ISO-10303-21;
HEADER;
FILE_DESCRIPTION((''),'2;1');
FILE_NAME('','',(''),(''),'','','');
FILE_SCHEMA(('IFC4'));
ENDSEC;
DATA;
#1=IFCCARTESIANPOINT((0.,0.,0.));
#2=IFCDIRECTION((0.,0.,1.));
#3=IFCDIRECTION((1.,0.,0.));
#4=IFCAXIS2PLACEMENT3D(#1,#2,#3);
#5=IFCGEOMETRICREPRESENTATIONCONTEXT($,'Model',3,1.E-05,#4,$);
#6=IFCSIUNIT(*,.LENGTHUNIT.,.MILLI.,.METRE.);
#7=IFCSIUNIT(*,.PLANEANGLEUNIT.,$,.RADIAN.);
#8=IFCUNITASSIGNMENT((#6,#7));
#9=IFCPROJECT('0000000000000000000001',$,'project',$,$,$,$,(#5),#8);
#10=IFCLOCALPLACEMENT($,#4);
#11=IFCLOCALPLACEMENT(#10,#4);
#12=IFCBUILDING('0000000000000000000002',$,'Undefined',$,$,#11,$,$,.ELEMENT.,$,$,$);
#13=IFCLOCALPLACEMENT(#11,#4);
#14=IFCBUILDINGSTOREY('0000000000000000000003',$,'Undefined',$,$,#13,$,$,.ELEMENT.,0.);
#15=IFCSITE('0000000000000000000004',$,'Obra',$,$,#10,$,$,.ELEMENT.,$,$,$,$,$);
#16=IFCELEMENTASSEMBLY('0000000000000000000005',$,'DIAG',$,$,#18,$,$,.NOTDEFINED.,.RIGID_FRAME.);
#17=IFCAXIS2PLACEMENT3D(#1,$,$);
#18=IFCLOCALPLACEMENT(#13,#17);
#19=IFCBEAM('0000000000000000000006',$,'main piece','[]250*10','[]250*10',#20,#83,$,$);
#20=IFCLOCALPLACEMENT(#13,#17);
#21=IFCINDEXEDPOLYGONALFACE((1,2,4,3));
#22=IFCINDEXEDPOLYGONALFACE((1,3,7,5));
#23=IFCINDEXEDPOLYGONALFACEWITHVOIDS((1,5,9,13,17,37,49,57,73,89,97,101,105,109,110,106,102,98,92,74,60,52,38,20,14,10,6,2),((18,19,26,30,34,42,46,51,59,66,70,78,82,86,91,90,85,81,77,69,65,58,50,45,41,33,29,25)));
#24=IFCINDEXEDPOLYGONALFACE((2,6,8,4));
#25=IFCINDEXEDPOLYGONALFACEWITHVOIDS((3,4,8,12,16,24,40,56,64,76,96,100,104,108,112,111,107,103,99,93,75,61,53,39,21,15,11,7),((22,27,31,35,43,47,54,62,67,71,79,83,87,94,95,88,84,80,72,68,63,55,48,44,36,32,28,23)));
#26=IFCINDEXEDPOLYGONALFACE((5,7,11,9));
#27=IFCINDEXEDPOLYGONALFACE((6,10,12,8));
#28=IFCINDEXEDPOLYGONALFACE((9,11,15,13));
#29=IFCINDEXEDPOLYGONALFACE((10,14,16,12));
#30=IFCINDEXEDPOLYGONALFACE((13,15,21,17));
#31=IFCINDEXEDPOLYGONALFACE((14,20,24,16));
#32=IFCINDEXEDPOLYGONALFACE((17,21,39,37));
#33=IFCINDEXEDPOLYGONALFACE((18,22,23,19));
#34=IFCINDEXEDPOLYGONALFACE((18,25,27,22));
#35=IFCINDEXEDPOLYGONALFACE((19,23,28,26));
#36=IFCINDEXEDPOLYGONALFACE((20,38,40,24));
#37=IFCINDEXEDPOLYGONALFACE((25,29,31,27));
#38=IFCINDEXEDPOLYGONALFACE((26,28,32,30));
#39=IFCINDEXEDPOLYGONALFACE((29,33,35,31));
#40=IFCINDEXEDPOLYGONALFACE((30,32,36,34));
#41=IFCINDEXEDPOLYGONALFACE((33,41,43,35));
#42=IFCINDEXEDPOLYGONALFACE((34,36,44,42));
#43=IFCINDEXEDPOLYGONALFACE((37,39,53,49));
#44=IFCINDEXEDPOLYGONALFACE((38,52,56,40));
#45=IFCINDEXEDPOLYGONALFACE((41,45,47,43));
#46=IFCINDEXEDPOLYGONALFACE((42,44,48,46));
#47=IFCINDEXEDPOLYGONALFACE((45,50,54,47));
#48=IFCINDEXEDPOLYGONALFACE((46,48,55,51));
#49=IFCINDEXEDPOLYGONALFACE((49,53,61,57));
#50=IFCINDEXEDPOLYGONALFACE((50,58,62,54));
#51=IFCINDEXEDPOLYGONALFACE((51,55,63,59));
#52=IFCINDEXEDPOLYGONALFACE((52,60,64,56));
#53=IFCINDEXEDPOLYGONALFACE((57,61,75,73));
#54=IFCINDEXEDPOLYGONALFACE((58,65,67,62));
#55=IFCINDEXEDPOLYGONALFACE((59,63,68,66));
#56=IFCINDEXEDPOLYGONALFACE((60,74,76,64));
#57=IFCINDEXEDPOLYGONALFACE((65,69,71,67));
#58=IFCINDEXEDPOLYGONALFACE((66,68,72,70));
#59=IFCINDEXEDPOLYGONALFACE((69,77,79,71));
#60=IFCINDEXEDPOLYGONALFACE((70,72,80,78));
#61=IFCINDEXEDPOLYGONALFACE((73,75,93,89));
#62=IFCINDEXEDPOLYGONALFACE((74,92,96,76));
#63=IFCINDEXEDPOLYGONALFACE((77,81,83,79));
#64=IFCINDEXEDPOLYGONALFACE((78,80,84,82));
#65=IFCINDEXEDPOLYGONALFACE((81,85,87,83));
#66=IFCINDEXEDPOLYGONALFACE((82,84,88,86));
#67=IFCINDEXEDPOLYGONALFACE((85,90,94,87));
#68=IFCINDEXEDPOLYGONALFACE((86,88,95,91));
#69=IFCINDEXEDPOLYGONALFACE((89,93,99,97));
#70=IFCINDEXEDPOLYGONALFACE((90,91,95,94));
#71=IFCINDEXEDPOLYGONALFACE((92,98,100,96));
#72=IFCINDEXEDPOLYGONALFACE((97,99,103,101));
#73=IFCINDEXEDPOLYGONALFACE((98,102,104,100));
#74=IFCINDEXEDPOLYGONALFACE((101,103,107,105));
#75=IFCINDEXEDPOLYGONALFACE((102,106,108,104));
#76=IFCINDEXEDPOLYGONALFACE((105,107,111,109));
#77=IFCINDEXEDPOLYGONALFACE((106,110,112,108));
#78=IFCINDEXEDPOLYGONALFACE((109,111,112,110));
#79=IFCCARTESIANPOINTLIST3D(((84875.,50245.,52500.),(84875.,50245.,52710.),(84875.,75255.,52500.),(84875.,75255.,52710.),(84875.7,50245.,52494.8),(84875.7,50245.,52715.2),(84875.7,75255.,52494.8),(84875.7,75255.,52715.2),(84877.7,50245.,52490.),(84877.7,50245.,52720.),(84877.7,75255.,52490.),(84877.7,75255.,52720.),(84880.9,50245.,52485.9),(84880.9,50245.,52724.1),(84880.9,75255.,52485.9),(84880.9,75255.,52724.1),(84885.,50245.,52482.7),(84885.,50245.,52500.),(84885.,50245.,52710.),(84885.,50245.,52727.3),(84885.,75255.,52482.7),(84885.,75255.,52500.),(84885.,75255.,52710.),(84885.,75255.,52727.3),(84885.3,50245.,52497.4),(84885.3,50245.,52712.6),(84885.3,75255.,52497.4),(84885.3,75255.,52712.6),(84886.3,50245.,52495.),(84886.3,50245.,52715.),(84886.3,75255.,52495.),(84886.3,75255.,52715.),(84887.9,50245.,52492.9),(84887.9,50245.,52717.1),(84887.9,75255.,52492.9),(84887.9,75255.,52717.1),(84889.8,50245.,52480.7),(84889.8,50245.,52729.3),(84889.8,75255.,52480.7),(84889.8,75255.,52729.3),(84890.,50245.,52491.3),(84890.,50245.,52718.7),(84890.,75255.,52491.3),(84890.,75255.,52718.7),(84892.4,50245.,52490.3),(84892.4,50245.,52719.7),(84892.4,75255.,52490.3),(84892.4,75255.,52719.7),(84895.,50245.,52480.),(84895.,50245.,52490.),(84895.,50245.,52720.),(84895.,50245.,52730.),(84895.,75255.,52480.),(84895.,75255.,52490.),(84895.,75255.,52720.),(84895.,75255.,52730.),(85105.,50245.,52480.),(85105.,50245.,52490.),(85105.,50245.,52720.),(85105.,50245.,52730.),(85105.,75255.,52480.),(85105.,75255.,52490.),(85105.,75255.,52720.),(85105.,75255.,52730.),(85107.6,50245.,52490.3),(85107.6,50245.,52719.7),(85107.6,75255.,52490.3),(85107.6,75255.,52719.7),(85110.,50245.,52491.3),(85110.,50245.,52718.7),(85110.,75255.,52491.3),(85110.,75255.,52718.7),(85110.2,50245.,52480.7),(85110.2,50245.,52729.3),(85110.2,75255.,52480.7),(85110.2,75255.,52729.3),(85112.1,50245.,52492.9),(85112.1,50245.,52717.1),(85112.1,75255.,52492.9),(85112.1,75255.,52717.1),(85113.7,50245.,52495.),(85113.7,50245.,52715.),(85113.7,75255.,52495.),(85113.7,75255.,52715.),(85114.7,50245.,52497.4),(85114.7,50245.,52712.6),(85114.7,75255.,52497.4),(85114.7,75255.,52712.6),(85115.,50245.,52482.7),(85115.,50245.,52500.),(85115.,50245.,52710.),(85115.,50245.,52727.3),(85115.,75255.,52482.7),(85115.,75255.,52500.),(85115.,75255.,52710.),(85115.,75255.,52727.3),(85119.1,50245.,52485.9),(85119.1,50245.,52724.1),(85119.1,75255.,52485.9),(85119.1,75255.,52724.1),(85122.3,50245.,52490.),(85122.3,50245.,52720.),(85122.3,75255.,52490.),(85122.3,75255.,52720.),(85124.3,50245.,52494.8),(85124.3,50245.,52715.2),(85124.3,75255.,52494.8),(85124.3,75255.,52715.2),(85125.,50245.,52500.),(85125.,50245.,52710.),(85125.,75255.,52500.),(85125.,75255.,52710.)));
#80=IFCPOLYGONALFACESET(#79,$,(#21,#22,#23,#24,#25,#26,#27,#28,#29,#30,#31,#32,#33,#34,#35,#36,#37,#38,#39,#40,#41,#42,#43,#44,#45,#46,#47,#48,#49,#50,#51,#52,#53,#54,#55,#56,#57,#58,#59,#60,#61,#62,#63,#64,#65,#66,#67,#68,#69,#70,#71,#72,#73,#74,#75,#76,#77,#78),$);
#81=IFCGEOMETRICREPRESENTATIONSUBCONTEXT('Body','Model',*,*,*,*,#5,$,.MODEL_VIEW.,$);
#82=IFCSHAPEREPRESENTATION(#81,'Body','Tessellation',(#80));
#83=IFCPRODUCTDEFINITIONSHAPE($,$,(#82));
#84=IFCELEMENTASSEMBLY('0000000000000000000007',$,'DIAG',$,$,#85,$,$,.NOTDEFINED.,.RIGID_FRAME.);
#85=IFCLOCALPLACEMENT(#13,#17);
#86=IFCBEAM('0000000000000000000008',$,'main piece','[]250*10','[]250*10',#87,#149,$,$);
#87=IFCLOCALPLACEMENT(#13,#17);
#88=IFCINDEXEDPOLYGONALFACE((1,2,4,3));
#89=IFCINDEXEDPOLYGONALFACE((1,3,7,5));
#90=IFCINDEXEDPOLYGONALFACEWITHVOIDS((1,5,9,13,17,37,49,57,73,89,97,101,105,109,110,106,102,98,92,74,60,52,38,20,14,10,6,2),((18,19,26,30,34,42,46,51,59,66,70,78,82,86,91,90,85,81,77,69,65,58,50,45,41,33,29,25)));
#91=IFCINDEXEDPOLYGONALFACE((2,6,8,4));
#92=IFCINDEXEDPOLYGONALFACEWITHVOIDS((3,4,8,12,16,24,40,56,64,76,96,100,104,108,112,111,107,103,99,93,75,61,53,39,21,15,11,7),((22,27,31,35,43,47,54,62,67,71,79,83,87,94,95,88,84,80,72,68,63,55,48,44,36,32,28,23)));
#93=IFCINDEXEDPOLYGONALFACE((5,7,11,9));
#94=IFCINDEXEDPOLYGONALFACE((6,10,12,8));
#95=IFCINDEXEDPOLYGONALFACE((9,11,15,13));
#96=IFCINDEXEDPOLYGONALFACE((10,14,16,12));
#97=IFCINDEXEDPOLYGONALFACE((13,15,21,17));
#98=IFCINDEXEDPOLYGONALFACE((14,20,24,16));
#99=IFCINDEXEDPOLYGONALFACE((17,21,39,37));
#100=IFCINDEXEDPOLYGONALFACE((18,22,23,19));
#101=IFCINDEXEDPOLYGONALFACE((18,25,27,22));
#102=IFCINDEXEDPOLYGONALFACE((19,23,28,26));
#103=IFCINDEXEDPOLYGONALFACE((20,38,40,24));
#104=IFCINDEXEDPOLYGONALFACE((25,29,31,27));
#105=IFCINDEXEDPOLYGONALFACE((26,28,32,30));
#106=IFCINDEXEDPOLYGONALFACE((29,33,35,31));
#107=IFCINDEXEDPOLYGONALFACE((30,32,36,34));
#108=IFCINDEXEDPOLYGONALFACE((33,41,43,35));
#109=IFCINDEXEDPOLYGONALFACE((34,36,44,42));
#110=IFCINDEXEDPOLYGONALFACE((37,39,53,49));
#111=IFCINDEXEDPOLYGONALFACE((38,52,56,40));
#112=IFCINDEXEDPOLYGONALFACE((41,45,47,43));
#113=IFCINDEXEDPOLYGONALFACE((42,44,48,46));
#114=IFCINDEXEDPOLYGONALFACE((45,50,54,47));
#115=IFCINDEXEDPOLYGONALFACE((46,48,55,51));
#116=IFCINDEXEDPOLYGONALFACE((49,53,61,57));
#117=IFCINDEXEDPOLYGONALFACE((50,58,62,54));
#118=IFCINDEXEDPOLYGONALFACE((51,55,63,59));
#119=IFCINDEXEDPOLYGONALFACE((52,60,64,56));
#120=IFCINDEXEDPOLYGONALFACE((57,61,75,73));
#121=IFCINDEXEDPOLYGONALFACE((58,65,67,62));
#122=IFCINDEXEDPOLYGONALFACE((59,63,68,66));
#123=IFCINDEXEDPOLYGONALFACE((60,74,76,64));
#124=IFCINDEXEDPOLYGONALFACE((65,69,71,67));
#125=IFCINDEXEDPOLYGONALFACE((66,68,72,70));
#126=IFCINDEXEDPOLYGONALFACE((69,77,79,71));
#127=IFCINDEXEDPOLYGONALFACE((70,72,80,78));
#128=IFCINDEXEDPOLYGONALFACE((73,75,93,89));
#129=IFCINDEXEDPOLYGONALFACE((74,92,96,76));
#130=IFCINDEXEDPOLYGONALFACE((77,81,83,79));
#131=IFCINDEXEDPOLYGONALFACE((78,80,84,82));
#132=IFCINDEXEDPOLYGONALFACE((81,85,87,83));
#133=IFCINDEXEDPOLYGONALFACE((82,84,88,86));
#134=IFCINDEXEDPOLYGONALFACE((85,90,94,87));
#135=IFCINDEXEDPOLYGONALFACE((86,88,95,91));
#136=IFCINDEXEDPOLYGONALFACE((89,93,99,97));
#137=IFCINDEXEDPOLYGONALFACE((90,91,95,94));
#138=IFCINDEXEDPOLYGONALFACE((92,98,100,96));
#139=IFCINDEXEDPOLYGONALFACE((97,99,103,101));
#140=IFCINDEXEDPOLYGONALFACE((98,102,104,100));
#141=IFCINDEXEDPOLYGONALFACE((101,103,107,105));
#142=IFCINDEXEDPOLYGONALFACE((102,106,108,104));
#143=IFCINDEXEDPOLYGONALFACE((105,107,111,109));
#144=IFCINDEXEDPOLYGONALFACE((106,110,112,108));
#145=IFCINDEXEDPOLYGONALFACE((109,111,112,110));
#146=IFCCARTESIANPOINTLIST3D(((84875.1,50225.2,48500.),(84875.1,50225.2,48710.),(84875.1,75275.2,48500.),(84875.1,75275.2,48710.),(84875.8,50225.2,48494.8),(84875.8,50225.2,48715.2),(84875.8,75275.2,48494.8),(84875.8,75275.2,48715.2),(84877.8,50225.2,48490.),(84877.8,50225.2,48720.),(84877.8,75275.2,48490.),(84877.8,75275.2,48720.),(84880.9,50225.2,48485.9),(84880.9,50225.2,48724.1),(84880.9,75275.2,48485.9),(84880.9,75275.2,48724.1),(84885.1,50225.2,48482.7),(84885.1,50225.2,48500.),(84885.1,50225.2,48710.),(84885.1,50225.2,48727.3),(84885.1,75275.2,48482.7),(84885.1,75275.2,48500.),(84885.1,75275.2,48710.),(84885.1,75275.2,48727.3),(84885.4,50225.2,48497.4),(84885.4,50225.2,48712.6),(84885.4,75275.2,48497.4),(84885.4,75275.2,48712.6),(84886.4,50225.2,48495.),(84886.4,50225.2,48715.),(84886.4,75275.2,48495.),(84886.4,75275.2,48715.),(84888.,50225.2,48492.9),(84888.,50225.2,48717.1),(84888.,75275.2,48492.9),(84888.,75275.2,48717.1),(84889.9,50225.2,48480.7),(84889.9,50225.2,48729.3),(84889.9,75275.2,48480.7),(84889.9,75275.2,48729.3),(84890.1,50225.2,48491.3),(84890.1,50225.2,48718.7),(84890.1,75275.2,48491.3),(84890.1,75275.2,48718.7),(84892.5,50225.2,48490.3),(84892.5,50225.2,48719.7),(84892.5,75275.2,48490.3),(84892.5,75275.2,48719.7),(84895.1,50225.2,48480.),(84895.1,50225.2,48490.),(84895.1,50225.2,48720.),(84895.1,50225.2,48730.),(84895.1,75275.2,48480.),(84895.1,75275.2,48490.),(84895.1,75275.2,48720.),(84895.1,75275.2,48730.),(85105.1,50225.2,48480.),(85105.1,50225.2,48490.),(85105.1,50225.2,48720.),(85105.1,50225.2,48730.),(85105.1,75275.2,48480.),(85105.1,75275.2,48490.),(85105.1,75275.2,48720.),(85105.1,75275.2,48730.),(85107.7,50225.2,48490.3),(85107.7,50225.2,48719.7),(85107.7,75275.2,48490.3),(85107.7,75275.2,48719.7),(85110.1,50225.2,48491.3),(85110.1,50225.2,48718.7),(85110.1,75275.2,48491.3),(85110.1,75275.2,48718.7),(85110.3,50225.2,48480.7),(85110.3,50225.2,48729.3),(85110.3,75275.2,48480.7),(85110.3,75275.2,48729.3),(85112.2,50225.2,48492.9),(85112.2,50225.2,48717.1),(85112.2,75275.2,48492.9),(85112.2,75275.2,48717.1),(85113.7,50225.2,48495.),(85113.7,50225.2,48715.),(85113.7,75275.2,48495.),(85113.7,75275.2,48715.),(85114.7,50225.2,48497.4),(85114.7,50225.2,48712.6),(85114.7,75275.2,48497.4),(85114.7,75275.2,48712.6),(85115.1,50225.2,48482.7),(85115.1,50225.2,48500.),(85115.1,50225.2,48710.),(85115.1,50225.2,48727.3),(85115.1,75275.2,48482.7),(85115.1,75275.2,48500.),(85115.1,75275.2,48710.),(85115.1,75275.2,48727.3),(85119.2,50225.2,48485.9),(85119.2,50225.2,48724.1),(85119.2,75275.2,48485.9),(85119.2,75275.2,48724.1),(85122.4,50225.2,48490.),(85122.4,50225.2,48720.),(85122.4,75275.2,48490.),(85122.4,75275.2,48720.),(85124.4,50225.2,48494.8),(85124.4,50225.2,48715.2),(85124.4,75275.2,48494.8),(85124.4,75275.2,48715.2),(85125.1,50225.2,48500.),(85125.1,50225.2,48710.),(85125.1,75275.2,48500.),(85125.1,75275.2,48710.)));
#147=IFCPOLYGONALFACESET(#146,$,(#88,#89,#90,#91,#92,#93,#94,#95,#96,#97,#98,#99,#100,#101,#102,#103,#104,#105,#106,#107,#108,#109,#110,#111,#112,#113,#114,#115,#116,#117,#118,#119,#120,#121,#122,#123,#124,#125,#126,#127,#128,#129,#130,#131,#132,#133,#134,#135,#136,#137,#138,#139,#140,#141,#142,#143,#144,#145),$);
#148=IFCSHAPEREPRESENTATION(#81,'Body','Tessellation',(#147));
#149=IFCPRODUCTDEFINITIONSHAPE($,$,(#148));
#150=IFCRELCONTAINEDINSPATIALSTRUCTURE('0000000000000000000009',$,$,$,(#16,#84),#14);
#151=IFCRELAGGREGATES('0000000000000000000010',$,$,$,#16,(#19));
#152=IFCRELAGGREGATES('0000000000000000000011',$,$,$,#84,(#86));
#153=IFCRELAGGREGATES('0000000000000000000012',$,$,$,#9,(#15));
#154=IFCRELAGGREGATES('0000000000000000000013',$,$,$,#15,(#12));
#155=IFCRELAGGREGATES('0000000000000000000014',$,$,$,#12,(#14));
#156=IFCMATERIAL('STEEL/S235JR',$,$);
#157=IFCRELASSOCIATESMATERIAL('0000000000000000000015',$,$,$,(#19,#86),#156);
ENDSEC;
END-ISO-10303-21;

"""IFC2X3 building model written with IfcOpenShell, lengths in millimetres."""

from ifc_helpers import new_model, si_unit, frame, origin_with_axes, origin_2d_with_axis, place, context, subcontext, project, spatial, hollow_rectangle, extrude, material, element, aggregate, save


model = new_model("IFC2X3")

# Units and contexts
model_context = context("Model", 3, precision=1e-05, world=origin_with_axes())
body_context = subcontext(model_context, "Body", "Model", "MODEL_VIEW")
ifc_project = project(units=[si_unit("LENGTHUNIT", "METRE", prefix="MILLI"), si_unit("PLANEANGLEUNIT", "RADIAN")], contexts=[model_context])

# Site, building, storey
site_placement = place(None, origin_with_axes())
site = spatial("IfcSite", under=ifc_project, at=site_placement, Name="Obra", CompositionType="ELEMENT")
building_placement = place(site_placement, origin_with_axes())
building = spatial("IfcBuilding", under=site, at=building_placement, Name="Undefined", CompositionType="ELEMENT")
storey_placement = place(building_placement, origin_with_axes())
storey = spatial("IfcBuildingStorey", under=building, at=storey_placement, Name="Undefined", CompositionType="ELEMENT", Elevation=0.0)

# Shared definitions
ifc_material = material(Name="STEEL/S235JR")

# Element assemblies, beams
assembly_1_placement = place(storey_placement, origin_with_axes())
assembly_1 = element("IfcElementAssembly", 1, at=assembly_1_placement, inside=storey, Name="DIAG", AssemblyPlace="NOTDEFINED", PredefinedType="RIGID_FRAME")
beam_1_placement = place(assembly_1_placement, frame((85000.0, 50245.0, 52605.0), z_axis=(0.0, 0.0, 1.0), x_axis=(0.0, 1.0, 0.0)))
beam_1 = element("IfcBeam", 2, at=beam_1_placement, material=ifc_material, Name="main piece", Description="[]250*10", ObjectType="[]250*10", context=body_context, shape_type="SweptSolid", body=[
    extrude(hollow_rectangle(XDim=250.0, YDim=250.0, WallThickness=10.0, InnerFilletRadius=10.0, OuterFilletRadius=20.0, at=origin_2d_with_axis()), frame((25010.0, 0.0, 0.0), z_axis=(-1.0, 0.0, 0.0), x_axis=(0.0, -1.0, 0.0)), (0.0, 0.0, 1.0), 25010.0),
])
aggregate(assembly_1, [beam_1])
assembly_2_placement = place(storey_placement, origin_with_axes())
assembly_2 = element("IfcElementAssembly", 3, at=assembly_2_placement, inside=storey, Name="DIAG", AssemblyPlace="NOTDEFINED", PredefinedType="RIGID_FRAME")
beam_2_placement = place(assembly_2_placement, frame((85000.1, 50225.2, 48605.0), z_axis=(0.0, 0.0, 1.0), x_axis=(0.0, 1.0, 0.0)))
beam_2 = element("IfcBeam", 4, at=beam_2_placement, material=ifc_material, Name="main piece", Description="[]250*10", ObjectType="[]250*10", context=body_context, shape_type="SweptSolid", body=[
    extrude(hollow_rectangle(XDim=250.0, YDim=250.0, WallThickness=10.0, InnerFilletRadius=10.0, OuterFilletRadius=20.0, at=origin_2d_with_axis()), frame((25050.0, 0.0, 0.0), z_axis=(-1.0, 0.0, 0.0), x_axis=(0.0, -1.0, 0.0)), (0.0, 0.0, 1.0), 25050.0),
])
aggregate(assembly_2, [beam_2])

save(model, "model.ifc")
